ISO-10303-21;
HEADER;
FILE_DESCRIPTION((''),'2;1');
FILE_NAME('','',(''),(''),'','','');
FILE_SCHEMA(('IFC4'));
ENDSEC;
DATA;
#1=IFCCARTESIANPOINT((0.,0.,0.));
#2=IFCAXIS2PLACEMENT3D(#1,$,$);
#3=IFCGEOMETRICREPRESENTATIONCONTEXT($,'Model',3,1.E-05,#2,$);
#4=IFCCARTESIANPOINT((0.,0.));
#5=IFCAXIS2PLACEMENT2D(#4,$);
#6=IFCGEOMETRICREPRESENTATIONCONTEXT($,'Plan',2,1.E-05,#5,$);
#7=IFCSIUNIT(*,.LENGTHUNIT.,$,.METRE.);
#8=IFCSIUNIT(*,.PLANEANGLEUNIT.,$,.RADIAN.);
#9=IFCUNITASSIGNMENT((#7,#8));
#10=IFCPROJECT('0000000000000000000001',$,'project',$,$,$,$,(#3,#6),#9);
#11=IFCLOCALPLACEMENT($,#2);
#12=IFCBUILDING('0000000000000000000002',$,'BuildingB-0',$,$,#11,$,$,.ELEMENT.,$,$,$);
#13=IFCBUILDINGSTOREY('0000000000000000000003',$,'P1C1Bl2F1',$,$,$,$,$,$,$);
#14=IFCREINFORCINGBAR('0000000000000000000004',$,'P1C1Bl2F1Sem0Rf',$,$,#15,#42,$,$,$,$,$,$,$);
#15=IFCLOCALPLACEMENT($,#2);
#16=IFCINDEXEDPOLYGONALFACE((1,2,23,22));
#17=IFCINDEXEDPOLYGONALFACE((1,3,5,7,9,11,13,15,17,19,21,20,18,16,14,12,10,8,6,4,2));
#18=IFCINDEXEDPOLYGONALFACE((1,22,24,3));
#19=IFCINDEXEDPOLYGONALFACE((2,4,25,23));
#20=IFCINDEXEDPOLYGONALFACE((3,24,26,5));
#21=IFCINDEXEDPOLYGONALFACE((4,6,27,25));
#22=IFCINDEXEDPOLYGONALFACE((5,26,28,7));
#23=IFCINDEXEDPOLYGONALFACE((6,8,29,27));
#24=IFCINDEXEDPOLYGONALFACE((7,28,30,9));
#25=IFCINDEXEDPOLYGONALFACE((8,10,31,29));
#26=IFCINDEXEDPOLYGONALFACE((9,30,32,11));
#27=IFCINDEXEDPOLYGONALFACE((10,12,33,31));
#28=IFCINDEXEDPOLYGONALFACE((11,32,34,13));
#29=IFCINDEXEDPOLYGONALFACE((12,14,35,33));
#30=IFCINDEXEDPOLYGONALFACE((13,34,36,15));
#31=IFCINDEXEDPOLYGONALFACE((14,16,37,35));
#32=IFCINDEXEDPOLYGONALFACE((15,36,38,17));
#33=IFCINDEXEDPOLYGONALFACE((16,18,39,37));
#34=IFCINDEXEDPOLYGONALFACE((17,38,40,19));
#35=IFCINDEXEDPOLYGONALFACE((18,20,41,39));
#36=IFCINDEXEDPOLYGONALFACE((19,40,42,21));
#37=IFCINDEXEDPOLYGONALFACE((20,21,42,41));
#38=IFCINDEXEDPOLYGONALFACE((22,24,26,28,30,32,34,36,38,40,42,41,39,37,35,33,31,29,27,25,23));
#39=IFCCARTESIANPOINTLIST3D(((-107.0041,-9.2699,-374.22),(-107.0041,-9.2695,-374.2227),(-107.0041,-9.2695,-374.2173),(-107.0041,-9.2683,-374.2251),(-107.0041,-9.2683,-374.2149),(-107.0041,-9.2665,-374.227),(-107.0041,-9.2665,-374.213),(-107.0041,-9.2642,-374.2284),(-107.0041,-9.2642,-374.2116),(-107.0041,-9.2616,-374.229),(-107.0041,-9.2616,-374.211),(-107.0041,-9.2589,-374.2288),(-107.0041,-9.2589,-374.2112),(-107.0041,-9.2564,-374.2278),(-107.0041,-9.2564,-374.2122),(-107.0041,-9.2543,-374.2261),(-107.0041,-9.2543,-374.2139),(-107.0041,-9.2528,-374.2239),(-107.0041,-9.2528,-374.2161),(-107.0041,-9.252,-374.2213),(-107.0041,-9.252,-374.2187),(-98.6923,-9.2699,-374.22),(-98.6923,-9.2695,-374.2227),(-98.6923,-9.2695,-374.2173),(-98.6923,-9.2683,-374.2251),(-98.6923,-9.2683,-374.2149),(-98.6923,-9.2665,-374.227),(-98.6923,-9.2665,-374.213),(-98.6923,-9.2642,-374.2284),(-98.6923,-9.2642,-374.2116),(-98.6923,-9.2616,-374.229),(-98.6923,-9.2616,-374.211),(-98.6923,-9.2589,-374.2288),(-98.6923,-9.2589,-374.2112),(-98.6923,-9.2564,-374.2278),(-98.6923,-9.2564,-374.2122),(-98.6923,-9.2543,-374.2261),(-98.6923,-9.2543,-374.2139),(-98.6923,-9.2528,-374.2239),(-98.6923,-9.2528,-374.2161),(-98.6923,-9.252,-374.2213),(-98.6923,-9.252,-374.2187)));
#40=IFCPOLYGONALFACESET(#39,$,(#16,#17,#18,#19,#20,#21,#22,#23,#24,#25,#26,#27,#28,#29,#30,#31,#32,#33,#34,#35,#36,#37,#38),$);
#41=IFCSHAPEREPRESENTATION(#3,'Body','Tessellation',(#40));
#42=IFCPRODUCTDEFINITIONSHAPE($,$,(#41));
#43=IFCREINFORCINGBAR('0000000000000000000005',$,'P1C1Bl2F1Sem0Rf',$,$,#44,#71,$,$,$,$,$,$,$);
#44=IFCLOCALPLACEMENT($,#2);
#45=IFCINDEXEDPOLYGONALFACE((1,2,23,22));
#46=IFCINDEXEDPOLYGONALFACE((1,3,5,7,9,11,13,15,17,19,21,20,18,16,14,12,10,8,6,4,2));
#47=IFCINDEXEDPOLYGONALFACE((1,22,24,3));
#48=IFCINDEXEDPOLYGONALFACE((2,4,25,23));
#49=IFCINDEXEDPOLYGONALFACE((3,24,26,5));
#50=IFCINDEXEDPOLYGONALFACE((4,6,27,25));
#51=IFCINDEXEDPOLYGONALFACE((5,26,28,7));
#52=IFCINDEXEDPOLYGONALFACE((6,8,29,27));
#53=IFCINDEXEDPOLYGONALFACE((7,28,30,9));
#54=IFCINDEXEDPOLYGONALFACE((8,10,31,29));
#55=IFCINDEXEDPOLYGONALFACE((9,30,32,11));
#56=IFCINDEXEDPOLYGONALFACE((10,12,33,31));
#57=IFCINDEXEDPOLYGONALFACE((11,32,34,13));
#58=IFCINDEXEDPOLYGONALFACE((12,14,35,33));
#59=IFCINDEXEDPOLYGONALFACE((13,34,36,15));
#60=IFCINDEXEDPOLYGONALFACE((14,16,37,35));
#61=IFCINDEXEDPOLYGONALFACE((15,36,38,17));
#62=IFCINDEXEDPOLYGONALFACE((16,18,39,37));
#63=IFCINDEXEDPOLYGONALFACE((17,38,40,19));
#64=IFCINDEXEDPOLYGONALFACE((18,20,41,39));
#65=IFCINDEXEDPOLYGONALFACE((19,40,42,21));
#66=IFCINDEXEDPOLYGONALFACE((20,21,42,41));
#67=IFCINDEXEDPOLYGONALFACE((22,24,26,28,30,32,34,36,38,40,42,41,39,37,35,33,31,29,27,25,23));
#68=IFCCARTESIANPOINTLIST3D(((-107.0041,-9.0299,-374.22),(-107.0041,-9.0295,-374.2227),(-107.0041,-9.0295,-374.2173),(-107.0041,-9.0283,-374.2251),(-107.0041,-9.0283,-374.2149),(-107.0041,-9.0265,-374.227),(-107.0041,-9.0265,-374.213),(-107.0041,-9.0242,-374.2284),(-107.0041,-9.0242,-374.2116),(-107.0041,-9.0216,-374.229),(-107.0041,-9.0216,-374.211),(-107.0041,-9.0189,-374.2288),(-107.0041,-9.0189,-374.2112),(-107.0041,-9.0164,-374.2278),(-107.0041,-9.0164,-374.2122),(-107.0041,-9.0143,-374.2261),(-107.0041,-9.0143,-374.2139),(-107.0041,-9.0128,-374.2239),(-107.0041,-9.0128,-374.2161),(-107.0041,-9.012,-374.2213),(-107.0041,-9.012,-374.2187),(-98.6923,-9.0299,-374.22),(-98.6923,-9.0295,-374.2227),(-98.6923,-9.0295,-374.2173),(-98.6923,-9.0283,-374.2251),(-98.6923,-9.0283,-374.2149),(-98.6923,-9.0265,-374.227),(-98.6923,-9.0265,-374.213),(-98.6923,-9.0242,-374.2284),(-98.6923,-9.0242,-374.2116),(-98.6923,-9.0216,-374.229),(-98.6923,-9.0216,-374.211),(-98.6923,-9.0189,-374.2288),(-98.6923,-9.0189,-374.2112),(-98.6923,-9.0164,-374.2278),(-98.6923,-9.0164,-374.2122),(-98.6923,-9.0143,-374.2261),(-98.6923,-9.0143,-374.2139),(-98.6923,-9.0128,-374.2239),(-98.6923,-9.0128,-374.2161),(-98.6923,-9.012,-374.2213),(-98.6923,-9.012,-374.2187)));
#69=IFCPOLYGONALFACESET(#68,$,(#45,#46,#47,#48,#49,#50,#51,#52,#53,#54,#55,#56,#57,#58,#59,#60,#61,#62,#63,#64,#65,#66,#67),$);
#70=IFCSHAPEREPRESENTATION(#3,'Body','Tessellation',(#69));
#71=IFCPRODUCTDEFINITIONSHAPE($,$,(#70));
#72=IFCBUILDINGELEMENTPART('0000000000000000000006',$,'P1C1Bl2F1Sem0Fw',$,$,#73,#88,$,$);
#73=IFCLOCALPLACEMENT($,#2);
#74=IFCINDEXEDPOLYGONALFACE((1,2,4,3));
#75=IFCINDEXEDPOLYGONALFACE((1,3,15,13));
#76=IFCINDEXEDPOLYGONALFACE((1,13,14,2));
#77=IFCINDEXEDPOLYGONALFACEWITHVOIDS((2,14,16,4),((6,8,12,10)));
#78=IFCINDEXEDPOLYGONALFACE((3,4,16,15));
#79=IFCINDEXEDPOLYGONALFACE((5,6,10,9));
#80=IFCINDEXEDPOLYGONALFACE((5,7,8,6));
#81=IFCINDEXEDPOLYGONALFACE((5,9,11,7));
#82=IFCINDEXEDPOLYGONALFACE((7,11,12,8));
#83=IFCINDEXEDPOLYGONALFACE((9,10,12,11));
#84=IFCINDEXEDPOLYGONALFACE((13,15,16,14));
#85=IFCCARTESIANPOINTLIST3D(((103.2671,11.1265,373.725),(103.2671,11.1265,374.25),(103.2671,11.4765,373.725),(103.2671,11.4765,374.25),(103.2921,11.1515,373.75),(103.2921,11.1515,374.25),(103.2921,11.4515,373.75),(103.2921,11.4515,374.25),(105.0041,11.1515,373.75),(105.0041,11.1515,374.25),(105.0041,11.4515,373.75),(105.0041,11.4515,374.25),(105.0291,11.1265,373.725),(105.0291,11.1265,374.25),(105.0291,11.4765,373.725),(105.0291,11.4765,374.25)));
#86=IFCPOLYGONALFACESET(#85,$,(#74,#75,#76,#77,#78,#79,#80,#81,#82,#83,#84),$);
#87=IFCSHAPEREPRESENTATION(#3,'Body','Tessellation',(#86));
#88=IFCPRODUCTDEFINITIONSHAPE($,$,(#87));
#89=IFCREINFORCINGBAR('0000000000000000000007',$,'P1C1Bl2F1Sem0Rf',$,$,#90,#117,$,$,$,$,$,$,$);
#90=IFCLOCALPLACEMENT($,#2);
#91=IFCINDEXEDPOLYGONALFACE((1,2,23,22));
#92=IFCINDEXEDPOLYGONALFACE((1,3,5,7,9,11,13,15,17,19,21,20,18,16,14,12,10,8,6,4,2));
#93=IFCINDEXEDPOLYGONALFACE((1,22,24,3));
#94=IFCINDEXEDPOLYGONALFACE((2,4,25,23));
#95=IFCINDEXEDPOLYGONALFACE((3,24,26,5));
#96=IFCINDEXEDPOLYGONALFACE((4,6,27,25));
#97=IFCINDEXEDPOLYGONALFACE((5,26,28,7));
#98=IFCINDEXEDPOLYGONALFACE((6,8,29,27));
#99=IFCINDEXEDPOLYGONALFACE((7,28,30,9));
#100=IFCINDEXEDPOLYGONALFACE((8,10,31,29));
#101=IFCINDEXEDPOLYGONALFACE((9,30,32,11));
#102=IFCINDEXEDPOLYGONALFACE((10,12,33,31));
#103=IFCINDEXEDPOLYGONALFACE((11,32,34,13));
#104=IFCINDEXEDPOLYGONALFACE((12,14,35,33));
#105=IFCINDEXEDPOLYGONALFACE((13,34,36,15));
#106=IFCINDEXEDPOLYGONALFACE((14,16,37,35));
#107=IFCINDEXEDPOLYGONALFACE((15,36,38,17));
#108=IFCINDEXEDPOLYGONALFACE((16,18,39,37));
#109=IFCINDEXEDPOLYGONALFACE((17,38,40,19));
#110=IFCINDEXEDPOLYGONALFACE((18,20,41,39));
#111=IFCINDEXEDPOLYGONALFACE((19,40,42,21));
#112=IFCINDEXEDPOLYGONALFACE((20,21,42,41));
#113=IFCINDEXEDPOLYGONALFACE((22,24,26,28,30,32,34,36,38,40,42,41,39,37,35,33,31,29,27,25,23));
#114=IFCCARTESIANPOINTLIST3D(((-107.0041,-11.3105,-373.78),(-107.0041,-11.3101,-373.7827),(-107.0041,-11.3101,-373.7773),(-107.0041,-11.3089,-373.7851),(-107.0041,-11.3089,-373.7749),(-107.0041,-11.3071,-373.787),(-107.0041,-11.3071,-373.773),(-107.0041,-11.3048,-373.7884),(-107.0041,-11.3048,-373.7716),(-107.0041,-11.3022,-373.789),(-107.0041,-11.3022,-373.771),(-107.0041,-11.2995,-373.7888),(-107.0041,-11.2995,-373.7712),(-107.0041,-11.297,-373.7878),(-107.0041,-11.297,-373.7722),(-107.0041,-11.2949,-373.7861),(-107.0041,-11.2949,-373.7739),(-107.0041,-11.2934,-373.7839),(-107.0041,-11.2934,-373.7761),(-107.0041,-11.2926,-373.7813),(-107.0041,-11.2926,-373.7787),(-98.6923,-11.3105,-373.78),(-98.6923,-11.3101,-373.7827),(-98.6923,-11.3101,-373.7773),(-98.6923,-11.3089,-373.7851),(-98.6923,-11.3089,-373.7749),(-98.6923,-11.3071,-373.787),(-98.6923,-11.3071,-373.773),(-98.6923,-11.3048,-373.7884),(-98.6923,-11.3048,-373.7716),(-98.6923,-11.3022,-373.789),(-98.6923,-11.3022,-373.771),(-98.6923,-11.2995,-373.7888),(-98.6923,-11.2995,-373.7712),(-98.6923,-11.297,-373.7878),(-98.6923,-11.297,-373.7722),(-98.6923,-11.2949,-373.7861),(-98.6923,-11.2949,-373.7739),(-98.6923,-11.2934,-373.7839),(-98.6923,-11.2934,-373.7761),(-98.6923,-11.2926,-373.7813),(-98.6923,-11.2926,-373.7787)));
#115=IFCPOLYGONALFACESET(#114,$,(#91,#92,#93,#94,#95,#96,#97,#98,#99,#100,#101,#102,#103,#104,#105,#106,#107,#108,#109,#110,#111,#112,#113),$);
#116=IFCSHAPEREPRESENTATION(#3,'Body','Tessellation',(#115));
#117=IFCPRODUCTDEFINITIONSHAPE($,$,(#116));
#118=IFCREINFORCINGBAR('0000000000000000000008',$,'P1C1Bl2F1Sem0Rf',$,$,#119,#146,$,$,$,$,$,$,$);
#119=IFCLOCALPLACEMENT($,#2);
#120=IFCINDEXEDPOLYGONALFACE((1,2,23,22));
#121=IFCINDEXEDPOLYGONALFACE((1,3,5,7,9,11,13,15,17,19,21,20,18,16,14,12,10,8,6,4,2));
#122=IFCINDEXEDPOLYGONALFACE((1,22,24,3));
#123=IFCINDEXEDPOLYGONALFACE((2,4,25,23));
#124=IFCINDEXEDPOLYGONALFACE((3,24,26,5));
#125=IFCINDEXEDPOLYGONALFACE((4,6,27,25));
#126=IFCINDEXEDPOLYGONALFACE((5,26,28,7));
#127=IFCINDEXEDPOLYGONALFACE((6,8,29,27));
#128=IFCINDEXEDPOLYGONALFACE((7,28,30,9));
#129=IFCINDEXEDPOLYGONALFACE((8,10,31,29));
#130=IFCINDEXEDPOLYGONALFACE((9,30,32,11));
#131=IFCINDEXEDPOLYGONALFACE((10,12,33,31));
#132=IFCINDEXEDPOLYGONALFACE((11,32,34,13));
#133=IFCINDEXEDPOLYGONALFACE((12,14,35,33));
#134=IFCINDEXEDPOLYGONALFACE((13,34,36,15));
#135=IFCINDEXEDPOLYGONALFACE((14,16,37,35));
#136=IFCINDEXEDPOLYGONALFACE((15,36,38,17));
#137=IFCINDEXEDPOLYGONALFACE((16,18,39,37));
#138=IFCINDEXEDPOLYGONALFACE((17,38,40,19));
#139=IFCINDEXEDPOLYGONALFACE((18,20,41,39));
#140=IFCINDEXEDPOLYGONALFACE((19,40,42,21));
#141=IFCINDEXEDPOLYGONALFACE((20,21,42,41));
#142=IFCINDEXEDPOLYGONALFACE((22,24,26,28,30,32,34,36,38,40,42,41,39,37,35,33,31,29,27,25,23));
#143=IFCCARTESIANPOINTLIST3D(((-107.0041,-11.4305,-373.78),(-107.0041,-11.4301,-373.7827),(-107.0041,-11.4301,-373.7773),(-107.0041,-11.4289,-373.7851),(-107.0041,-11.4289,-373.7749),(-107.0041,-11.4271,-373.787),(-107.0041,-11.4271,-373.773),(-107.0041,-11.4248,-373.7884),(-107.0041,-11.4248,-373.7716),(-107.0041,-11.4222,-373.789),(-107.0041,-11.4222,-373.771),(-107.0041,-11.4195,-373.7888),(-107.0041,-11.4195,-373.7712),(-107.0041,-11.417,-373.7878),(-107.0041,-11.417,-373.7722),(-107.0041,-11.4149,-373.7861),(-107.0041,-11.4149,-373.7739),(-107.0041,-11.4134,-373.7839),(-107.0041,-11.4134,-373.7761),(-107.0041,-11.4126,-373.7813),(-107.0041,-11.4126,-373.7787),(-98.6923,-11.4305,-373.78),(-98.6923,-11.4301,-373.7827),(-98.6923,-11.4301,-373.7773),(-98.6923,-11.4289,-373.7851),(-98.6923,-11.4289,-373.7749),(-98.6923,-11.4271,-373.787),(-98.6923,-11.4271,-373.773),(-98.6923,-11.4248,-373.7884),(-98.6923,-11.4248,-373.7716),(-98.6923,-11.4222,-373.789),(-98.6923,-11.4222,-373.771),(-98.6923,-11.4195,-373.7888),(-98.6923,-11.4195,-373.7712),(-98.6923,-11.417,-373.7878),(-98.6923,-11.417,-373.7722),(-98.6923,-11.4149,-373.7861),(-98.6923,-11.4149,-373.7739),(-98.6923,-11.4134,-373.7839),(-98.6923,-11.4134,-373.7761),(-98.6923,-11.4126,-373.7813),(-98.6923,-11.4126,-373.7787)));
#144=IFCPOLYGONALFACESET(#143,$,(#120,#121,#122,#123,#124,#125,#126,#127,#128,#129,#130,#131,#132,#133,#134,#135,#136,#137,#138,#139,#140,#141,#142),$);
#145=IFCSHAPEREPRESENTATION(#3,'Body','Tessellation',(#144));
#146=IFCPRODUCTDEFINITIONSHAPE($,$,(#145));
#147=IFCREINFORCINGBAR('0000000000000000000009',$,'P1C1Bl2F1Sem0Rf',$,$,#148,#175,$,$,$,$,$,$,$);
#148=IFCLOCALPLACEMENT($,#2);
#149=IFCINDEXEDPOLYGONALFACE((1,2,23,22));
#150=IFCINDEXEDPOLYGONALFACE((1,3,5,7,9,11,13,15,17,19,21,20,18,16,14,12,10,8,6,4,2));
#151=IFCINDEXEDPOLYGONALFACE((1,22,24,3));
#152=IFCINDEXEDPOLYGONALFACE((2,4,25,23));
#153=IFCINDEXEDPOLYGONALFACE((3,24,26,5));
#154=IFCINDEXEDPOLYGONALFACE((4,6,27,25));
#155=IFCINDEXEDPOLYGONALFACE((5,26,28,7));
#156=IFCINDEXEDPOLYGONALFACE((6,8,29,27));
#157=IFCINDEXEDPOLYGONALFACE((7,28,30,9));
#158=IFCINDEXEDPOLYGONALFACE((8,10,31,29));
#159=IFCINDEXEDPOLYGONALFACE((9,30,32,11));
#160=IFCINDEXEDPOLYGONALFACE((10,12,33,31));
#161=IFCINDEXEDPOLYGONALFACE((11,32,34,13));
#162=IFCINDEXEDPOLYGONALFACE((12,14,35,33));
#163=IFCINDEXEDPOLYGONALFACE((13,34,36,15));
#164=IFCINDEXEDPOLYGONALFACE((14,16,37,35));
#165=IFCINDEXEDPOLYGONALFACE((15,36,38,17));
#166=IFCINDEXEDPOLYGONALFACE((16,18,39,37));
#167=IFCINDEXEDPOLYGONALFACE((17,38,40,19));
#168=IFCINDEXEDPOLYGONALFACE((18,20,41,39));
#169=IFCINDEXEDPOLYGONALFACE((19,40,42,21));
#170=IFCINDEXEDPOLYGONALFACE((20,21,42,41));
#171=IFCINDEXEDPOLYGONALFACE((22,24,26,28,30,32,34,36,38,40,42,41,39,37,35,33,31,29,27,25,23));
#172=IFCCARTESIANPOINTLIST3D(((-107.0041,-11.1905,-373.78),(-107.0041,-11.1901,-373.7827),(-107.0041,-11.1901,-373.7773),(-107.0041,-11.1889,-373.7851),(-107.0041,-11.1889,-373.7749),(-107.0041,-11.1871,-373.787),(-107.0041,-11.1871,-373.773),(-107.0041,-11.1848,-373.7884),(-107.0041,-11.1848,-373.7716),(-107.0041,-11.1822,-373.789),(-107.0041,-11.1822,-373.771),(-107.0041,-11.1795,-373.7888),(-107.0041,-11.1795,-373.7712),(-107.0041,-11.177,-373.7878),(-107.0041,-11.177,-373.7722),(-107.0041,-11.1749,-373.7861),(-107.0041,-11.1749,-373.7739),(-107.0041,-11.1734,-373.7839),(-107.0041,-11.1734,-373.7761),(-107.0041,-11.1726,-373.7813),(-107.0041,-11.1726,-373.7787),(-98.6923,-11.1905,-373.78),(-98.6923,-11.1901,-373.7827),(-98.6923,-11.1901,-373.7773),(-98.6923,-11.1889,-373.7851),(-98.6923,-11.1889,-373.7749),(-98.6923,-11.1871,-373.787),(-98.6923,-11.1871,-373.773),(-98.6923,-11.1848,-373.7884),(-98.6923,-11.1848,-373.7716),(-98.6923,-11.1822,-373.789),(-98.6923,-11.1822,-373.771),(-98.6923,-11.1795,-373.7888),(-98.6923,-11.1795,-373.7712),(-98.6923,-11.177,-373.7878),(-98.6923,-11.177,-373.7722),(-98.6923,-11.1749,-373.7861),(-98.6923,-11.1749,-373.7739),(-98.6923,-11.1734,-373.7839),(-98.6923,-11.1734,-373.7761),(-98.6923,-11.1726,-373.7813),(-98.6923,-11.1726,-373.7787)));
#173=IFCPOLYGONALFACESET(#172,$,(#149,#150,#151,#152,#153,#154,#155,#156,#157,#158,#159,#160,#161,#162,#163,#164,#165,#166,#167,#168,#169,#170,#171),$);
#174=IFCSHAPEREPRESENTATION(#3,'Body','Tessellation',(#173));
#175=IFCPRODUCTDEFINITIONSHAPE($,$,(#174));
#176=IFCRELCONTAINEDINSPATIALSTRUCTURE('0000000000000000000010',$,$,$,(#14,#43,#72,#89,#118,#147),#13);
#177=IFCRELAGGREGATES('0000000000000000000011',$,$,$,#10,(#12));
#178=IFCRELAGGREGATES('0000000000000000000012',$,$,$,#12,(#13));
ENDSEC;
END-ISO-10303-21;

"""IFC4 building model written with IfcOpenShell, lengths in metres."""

from ifc_helpers import new_model, entity, si_unit, origin, origin_2d, place, context, project, spatial, polyline, outline, extrude, element, save


model = new_model("IFC4")

# Units and contexts
model_context = context("Model", 3, precision=1e-05, world=origin())
plan_context = context("Plan", 2, precision=1e-05, world=origin_2d())
ifc_project = project(units=[si_unit("LENGTHUNIT", "METRE"), si_unit("PLANEANGLEUNIT", "RADIAN")], contexts=[model_context, plan_context])

# Building, storey
building_placement = place(None, origin())
building = spatial("IfcBuilding", under=ifc_project, at=building_placement, Name="BuildingB-0", CompositionType="ELEMENT")
storey = spatial("IfcBuildingStorey", under=building, Name="P1C1Bl2F1")

# Reinforcing bars
element("IfcReinforcingBar", 1, inside=storey, Name="P1C1Bl2F1Sem0Rf", context=model_context, shape_type="SweptSolid", body=[
    entity("IfcSurfaceCurveSweptAreaSolid", entity("IfcCircleProfileDef", "AREA", None, None, 0.009), None, entity("IfcPolyline", [entity("IfcCartesianPoint", [107.0041, 9.2609, 374.22]), entity("IfcCartesianPoint", [98.6923, 9.2609, 374.22])]), None, None, entity("IfcPlane", entity("IfcAxis2Placement3D", entity("IfcCartesianPoint", [107.0041, 9.2609, 374.22]), entity("IfcDirection", [0.0, 0.0, 1.0]), entity("IfcDirection", [1.0, 0.0, 0.0])))),
])
element("IfcReinforcingBar", 2, inside=storey, Name="P1C1Bl2F1Sem0Rf", context=model_context, shape_type="SweptSolid", body=[
    entity("IfcSurfaceCurveSweptAreaSolid", entity("IfcCircleProfileDef", "AREA", None, None, 0.009), None, entity("IfcPolyline", [entity("IfcCartesianPoint", [107.0041, 9.0209, 374.22]), entity("IfcCartesianPoint", [98.6923, 9.0209, 374.22])]), None, None, entity("IfcPlane", entity("IfcAxis2Placement3D", entity("IfcCartesianPoint", [107.0041, 9.0209, 374.22]), entity("IfcDirection", [0.0, 0.0, 1.0]), entity("IfcDirection", [1.0, 0.0, 0.0])))),
])

# Building element part, opening
building_element_part_1 = element("IfcBuildingElementPart", 3, inside=storey, Name="P1C1Bl2F1Sem0Fw", context=model_context, shape_type="SweptSolid", body=[
    extrude(outline(polyline([(105.0291, 11.1265, 373.725), (105.0291, 11.4765, 373.725), (103.2671, 11.4765, 373.725), (103.2671, 11.1265, 373.725), (105.0291, 11.1265, 373.725)])), None, (0.0, 0.0, 1.0), 0.525),
])
element("IfcOpeningElement", 4, inside=storey, cuts=building_element_part_1, context=model_context, shape_type="SweptSolid", body=[
    extrude(outline(polyline([(105.0041, 11.1515, 373.75), (105.0041, 11.4515, 373.75), (103.2921, 11.4515, 373.75), (103.2921, 11.1515, 373.75), (105.0041, 11.1515, 373.75)])), None, (0.0, 0.0, 1.0), 0.5),
])

# Reinforcing bars
element("IfcReinforcingBar", 5, inside=storey, Name="P1C1Bl2F1Sem0Rf", context=model_context, shape_type="SweptSolid", body=[
    entity("IfcSurfaceCurveSweptAreaSolid", entity("IfcCircleProfileDef", "AREA", None, None, 0.009), None, entity("IfcPolyline", [entity("IfcCartesianPoint", [107.0041, 11.3015, 373.78]), entity("IfcCartesianPoint", [98.6923, 11.3015, 373.78])]), None, None, entity("IfcPlane", entity("IfcAxis2Placement3D", entity("IfcCartesianPoint", [107.0041, 11.3015, 373.78]), entity("IfcDirection", [0.0, 0.0, 1.0]), entity("IfcDirection", [1.0, 0.0, 0.0])))),
])
element("IfcReinforcingBar", 6, inside=storey, Name="P1C1Bl2F1Sem0Rf", context=model_context, shape_type="SweptSolid", body=[
    entity("IfcSurfaceCurveSweptAreaSolid", entity("IfcCircleProfileDef", "AREA", None, None, 0.009), None, entity("IfcPolyline", [entity("IfcCartesianPoint", [107.0041, 11.4215, 373.78]), entity("IfcCartesianPoint", [98.6923, 11.4215, 373.78])]), None, None, entity("IfcPlane", entity("IfcAxis2Placement3D", entity("IfcCartesianPoint", [107.0041, 11.4215, 373.78]), entity("IfcDirection", [0.0, 0.0, 1.0]), entity("IfcDirection", [1.0, 0.0, 0.0])))),
])
element("IfcReinforcingBar", 7, inside=storey, Name="P1C1Bl2F1Sem0Rf", context=model_context, shape_type="SweptSolid", body=[
    entity("IfcSurfaceCurveSweptAreaSolid", entity("IfcCircleProfileDef", "AREA", None, None, 0.009), None, entity("IfcPolyline", [entity("IfcCartesianPoint", [107.0041, 11.1815, 373.78]), entity("IfcCartesianPoint", [98.6923, 11.1815, 373.78])]), None, None, entity("IfcPlane", entity("IfcAxis2Placement3D", entity("IfcCartesianPoint", [107.0041, 11.1815, 373.78]), entity("IfcDirection", [0.0, 0.0, 1.0]), entity("IfcDirection", [1.0, 0.0, 0.0])))),
])

save(model, "model.ifc")
